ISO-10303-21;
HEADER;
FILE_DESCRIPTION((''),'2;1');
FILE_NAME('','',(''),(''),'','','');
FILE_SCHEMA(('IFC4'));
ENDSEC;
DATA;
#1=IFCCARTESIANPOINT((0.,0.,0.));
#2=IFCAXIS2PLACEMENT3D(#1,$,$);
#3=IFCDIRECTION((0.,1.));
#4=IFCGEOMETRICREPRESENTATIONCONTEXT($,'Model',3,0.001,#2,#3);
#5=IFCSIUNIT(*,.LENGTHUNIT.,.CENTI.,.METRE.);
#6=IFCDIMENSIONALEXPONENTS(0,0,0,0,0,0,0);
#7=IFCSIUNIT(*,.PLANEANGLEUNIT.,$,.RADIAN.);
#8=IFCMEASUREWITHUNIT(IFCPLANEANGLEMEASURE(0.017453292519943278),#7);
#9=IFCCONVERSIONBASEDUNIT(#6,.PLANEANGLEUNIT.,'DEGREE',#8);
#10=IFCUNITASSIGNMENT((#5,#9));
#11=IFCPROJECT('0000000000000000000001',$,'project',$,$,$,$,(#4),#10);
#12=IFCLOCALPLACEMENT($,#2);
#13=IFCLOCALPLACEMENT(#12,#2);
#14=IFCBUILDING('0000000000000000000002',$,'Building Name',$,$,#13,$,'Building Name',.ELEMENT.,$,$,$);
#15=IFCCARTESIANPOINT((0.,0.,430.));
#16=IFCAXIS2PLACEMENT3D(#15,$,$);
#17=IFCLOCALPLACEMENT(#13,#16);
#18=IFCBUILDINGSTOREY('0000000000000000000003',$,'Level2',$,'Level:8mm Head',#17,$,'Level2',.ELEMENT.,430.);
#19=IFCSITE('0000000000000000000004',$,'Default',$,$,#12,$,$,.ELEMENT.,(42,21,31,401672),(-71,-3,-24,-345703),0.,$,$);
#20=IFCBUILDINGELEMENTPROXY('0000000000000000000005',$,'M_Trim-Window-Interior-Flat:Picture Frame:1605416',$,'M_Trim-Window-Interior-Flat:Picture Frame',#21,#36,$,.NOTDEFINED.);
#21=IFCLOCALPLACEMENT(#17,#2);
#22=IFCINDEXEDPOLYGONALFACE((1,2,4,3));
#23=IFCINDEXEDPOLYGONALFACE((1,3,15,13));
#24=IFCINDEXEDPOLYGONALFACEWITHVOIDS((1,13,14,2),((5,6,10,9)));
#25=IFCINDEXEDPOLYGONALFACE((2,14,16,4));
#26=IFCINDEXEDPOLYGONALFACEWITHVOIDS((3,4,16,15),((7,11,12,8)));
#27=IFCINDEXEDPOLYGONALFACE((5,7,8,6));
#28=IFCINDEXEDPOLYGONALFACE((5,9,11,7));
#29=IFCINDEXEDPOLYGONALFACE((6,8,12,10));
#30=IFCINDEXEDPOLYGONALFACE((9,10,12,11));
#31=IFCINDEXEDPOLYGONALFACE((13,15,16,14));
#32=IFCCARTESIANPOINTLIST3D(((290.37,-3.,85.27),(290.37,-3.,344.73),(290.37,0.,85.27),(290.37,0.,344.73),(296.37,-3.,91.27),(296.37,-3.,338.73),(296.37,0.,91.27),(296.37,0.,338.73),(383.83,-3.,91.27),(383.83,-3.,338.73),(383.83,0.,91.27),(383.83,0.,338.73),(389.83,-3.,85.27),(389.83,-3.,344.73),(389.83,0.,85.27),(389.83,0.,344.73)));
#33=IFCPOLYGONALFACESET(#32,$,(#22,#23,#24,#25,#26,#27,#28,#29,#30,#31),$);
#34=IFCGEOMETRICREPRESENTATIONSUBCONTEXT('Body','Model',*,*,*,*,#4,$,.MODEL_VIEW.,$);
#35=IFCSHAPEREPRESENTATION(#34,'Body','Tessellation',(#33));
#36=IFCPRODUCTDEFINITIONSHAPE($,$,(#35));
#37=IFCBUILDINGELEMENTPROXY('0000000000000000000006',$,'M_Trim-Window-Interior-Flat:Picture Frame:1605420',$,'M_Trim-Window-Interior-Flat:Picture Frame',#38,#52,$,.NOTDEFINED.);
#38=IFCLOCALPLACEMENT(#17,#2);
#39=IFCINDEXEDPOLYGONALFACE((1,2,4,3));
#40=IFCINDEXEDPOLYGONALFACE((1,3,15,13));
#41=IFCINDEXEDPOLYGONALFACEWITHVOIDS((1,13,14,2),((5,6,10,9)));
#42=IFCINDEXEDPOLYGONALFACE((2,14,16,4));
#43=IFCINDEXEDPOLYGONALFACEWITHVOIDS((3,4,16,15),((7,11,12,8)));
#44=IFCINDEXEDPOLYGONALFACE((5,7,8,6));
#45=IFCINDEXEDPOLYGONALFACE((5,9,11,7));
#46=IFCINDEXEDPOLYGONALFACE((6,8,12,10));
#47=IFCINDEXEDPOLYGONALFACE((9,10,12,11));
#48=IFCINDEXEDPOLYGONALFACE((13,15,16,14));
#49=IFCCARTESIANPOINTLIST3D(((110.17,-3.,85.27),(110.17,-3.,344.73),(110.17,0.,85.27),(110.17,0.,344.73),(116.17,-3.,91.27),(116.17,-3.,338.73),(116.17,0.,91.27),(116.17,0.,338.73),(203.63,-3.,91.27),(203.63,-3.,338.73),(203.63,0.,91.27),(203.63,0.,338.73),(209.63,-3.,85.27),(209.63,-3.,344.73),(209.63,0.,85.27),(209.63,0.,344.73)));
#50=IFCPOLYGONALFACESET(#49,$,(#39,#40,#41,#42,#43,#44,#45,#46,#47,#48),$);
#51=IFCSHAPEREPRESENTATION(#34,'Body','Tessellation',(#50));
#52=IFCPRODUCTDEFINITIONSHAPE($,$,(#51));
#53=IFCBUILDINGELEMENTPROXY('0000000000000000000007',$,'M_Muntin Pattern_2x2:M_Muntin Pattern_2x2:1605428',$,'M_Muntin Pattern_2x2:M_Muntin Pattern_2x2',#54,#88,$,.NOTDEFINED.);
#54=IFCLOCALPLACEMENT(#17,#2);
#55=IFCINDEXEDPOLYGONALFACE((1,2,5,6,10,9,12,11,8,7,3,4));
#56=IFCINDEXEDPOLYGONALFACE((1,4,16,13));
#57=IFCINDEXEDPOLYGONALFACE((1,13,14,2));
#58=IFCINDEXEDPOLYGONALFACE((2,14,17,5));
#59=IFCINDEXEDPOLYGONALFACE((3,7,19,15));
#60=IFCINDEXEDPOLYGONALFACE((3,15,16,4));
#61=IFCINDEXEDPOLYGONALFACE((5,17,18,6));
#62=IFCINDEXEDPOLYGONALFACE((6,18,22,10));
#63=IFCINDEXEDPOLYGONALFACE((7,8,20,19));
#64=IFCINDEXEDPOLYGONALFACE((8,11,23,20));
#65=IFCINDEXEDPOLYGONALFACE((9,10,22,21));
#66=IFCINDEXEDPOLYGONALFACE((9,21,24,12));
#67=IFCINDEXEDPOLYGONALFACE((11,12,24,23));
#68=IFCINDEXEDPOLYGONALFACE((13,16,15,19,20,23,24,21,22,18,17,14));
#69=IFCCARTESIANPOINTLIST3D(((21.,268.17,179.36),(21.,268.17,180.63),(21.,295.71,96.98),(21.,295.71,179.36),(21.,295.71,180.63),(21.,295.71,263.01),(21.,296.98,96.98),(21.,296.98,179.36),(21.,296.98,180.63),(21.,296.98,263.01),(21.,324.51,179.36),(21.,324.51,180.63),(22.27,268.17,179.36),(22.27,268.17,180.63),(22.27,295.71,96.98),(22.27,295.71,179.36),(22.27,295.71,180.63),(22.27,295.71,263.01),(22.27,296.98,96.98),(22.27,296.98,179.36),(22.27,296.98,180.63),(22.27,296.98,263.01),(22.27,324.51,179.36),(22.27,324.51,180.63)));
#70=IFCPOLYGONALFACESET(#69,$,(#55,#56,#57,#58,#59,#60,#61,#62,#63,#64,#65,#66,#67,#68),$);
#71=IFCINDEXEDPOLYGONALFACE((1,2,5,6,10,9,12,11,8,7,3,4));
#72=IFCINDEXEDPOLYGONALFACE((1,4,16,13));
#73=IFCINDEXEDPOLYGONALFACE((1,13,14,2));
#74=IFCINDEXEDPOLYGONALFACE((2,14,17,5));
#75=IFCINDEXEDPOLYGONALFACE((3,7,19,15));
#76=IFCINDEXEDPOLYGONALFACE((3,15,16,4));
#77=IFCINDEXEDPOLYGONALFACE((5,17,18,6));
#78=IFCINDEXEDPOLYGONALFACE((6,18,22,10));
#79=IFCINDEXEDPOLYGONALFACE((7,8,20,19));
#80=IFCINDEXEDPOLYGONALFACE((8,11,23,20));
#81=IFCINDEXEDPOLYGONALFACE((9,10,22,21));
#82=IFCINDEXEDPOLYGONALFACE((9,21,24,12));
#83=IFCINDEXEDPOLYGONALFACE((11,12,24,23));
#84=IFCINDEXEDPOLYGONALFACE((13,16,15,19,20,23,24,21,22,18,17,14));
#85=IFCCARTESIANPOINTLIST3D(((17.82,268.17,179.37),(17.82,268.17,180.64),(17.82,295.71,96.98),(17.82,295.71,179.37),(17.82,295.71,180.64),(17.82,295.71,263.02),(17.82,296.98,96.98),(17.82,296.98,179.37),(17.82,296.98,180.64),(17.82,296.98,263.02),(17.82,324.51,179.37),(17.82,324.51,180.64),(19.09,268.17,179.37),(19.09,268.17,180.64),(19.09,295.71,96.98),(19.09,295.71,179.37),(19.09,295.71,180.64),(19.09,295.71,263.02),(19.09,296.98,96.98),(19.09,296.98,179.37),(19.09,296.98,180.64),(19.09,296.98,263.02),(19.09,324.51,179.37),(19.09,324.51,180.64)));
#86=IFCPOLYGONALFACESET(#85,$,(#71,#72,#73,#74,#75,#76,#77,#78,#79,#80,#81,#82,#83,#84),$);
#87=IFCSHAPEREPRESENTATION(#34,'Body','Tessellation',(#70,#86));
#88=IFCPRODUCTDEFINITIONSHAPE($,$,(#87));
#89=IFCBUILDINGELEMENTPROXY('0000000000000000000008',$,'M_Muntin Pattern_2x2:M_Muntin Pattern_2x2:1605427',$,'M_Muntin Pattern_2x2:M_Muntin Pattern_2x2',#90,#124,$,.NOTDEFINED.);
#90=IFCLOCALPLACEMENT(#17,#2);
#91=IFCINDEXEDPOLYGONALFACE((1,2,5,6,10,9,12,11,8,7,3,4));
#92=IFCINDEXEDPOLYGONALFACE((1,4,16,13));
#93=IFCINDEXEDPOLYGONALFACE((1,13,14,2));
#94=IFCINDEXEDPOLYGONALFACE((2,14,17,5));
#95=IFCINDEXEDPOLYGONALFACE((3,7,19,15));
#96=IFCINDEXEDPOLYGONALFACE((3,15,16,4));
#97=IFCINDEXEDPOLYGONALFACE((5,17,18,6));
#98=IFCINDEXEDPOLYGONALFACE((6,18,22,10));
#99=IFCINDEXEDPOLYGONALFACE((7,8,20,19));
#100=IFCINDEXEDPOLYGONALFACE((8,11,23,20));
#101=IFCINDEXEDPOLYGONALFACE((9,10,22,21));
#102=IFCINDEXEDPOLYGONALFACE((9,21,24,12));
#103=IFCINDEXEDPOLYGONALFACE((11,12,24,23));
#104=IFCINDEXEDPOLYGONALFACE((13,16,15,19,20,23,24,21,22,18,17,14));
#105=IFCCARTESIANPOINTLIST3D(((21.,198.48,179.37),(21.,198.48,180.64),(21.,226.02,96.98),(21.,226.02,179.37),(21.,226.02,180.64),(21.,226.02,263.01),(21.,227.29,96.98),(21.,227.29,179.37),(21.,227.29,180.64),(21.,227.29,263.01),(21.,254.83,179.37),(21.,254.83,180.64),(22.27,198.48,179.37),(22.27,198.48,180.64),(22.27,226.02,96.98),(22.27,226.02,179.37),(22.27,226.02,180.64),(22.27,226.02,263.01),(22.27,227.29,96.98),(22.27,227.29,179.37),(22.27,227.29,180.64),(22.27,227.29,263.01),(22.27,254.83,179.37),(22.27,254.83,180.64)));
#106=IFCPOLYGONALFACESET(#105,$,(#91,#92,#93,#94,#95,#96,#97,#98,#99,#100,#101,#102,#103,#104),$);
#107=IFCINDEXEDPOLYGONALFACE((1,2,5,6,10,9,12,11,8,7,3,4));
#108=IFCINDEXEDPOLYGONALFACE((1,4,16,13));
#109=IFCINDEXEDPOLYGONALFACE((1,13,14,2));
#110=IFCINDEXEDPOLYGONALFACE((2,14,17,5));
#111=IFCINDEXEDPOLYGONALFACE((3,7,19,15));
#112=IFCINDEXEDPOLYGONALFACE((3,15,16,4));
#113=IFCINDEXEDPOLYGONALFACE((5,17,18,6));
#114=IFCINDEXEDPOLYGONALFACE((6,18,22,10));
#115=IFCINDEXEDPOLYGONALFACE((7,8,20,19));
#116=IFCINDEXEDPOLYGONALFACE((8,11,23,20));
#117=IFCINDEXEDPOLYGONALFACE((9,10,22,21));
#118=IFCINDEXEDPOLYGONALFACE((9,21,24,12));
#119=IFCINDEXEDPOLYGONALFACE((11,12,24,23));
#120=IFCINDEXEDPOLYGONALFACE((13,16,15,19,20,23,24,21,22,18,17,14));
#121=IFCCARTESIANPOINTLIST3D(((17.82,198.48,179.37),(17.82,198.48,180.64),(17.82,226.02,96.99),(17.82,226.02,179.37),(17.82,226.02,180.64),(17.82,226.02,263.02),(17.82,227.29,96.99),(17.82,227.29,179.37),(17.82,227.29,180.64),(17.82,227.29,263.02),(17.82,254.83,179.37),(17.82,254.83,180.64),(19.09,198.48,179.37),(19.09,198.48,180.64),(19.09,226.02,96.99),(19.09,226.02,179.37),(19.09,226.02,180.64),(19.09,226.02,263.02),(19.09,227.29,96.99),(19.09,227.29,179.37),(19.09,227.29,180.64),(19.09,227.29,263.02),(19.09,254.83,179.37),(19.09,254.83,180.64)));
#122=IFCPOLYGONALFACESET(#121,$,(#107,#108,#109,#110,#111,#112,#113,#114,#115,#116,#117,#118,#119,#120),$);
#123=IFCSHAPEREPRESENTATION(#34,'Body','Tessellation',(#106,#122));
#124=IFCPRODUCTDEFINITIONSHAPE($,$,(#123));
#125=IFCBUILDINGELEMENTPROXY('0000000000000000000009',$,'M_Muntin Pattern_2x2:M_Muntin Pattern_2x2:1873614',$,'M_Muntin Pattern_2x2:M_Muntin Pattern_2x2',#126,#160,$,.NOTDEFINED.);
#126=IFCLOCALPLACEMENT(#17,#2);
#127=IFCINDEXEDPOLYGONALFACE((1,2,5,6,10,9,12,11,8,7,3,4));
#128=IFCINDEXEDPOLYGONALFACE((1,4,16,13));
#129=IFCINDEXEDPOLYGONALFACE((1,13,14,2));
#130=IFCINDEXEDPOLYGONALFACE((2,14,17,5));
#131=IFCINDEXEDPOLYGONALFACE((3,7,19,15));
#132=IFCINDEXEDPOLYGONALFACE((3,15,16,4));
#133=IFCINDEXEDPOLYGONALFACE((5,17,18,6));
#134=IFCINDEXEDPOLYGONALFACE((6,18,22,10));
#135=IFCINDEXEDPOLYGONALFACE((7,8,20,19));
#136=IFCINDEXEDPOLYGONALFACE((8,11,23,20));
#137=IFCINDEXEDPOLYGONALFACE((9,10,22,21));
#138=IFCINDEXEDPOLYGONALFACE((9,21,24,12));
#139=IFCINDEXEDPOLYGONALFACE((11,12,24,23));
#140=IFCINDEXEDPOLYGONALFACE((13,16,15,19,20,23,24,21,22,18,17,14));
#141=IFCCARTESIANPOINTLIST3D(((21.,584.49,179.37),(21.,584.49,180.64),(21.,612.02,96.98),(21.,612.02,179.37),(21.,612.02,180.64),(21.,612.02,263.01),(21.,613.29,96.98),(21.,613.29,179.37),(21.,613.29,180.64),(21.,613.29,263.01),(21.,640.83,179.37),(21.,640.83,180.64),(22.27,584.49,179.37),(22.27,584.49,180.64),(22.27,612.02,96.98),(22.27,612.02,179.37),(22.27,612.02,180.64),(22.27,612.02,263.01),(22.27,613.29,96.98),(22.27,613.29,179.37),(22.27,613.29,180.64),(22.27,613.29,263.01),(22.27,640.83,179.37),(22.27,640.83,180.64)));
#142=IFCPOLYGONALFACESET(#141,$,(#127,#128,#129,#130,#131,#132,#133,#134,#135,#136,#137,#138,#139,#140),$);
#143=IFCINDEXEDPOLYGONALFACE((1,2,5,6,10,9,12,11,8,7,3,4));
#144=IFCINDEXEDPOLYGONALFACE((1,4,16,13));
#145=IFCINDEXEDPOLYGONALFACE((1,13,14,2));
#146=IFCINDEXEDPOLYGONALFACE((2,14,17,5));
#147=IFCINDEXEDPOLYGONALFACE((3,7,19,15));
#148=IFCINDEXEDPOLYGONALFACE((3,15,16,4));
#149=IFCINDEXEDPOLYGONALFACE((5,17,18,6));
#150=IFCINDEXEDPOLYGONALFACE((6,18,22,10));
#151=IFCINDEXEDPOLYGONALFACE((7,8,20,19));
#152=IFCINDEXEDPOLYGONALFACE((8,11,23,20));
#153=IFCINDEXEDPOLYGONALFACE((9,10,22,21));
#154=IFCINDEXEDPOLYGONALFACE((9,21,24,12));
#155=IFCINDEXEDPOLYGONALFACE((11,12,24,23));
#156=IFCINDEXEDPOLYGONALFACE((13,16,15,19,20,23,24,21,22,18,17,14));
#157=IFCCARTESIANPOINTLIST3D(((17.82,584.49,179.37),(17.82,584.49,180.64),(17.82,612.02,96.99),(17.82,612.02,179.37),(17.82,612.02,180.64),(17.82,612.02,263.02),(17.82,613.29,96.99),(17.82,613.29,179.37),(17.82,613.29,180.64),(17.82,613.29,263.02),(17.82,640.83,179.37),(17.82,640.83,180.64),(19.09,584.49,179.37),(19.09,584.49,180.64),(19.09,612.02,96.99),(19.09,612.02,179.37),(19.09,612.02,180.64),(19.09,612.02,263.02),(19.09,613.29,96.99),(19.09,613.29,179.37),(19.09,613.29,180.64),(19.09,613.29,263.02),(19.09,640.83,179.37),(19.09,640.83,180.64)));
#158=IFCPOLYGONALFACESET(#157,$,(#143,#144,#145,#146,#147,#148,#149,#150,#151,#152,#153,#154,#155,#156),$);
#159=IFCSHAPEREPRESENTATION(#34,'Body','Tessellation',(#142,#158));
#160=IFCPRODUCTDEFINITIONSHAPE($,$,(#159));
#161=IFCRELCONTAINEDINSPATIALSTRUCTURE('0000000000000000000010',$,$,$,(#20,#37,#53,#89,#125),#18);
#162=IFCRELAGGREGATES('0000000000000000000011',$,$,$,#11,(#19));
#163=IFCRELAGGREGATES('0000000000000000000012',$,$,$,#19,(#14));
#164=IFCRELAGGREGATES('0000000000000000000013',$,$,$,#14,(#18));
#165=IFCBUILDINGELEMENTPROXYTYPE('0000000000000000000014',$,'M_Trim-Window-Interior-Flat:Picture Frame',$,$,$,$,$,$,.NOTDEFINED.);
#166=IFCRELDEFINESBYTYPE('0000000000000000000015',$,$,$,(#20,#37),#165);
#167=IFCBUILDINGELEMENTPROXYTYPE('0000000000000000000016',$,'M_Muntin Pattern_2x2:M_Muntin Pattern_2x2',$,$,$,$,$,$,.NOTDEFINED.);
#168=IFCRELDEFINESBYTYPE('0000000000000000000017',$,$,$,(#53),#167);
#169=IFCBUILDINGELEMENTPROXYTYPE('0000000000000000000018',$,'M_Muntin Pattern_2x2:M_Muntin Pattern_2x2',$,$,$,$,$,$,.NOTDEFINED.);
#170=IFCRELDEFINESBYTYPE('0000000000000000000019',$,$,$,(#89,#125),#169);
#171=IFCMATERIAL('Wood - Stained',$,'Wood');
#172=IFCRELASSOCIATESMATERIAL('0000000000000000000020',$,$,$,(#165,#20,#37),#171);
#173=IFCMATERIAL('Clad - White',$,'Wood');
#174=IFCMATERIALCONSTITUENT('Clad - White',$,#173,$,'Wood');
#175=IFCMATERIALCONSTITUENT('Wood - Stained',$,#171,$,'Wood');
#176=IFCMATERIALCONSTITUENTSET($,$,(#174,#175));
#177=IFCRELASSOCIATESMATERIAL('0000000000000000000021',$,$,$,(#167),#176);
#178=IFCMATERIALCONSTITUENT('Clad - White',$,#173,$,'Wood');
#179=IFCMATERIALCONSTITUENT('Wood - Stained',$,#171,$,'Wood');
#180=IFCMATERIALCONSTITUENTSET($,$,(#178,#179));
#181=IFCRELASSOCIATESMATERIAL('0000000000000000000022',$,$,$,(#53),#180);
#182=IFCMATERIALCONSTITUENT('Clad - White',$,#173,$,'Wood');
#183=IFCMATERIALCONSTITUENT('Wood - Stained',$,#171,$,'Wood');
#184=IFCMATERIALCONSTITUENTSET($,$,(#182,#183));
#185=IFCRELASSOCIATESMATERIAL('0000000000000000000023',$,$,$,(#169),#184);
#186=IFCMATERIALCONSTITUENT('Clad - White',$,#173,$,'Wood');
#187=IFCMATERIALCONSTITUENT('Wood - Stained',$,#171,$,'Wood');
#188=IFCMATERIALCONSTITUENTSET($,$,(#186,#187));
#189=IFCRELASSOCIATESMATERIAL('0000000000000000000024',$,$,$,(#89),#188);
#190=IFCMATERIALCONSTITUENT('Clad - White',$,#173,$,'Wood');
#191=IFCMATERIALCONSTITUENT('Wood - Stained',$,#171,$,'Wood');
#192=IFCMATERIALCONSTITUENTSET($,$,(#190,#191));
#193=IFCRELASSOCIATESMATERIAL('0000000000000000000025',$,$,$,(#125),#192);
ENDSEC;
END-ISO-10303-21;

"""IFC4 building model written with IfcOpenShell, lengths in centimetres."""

from ifc_helpers import new_model, entity, si_unit, converted_unit, direction, frame, origin, place, context, subcontext, project, spatial, indexed_curve, outline, extrude, source, transform, mapped, material, constituent, constituent_set, type_object, type_shapes, element, save


model = new_model("IFC4")

# Units and contexts
model_context = context("Model", 3, precision=0.001, world=origin(), true_north=direction((0.0, 1.0)))
body_context = subcontext(model_context, "Body", "Model", "MODEL_VIEW")
ifc_project = project(units=[si_unit("LENGTHUNIT", "METRE", prefix="CENTI"), converted_unit("PLANEANGLEUNIT", "DEGREE", entity("IfcPlaneAngleMeasure", 0.017453292519943278), si_unit("PLANEANGLEUNIT", "RADIAN"), dimensions=[0, 0, 0, 0, 0, 0, 0])], contexts=[model_context])

# Site, building, storey
site_placement = place(None, origin())
site = spatial("IfcSite", under=ifc_project, at=site_placement, Name="Default", CompositionType="ELEMENT", RefLatitude=(42, 21, 31, 401672), RefLongitude=(-71, -3, -24, -345703), RefElevation=0.0)
building_placement = place(site_placement, origin())
building = spatial("IfcBuilding", under=site, at=building_placement, Name="Building Name", LongName="Building Name", CompositionType="ELEMENT")
storey_placement = place(building_placement, frame((0.0, 0.0, 430.0)))
storey = spatial("IfcBuildingStorey", under=building, at=storey_placement, Name="Level2", ObjectType="Level:8mm Head", LongName="Level2", CompositionType="ELEMENT", Elevation=430.0)

# Building element proxies
ifc_material_1 = material(Name="Clad - White", Category="Wood")
ifc_material_2 = material(Name="Wood - Stained", Category="Wood")
building_element_proxy_type_1 = type_object("IfcBuildingElementProxyType", Name="M_Trim-Window-Interior-Flat:Picture Frame", PredefinedType="NOTDEFINED", material=ifc_material_2)
shared_shape_1 = source(origin(), body_context, "Body", "SweptSolid", [
    extrude(outline(indexed_curve([(-129.73, -49.73), (129.73, -49.73), (129.73, 49.73), (-129.73, 49.73), (-129.73, -49.73)], self_intersect=False), holes=[indexed_curve([(-123.73, -43.73), (-123.73, 43.73), (123.73, 43.73), (123.73, -43.73), (-123.73, -43.73)], self_intersect=False)]), frame((0.0, 125.0, 0.0), z_axis=(0.0, 0.0, 1.0), x_axis=(0.0, 1.0, 0.0)), (0.0, 0.0, 1.0), 3.0),
])
type_shapes(building_element_proxy_type_1, [shared_shape_1])
for number, where, z_axis, x_axis, name in (
    (1, (340.1, 0.0, 340.0), (0.0, -1.0, 0.0), (-1.0, 0.0, 0.0), "M_Trim-Window-Interior-Flat:Picture Frame:1605416"),
    (2, (159.9, 0.0, 340.0), (0.0, -1.0, 0.0), (-1.0, 0.0, 0.0), "M_Trim-Window-Interior-Flat:Picture Frame:1605420"),
):
    element("IfcBuildingElementProxy", number, at=place(storey_placement, frame(where, z_axis=z_axis, x_axis=x_axis)), inside=storey, type_object=building_element_proxy_type_1, material=ifc_material_2, Name=name, ObjectType="M_Trim-Window-Interior-Flat:Picture Frame", PredefinedType="NOTDEFINED", context=body_context, shape_type="MappedRepresentation", body=[
        mapped(shared_shape_1, transform((0.0, 0.0, 0.0), scale=1.0)),
    ])
ifc_constituent_1 = constituent(ifc_material_1, Name="Clad - White", Category="Wood")
ifc_constituent_2 = constituent(ifc_material_2, Name="Wood - Stained", Category="Wood")
ifc_constituent_set_1 = constituent_set(constituents=[ifc_constituent_1, ifc_constituent_2])
ifc_constituent_3 = constituent(ifc_material_1, Name="Clad - White", Category="Wood")
ifc_constituent_4 = constituent(ifc_material_2, Name="Wood - Stained", Category="Wood")
ifc_constituent_set_2 = constituent_set(constituents=[ifc_constituent_3, ifc_constituent_4])
building_element_proxy_type_2 = type_object("IfcBuildingElementProxyType", Name="M_Muntin Pattern_2x2:M_Muntin Pattern_2x2", PredefinedType="NOTDEFINED", material=ifc_constituent_set_2)
shared_shape_2 = source(origin(), body_context, "Body", "SweptSolid", [
    extrude(outline(indexed_curve([(0.64, -0.64), (83.01, -0.64), (83.01, 0.63), (0.64, 0.63), (0.64, 28.17), (-0.63, 28.17), (-0.63, 0.63), (-83.02, 0.63), (-83.02, -0.64), (-0.63, -0.64), (-0.63, -28.17), (0.64, -28.17), (0.64, -0.64)], self_intersect=False)), frame((0.0, 0.95, 83.01), z_axis=(0.0, 1.0, 0.0), x_axis=(0.0, 0.0, 1.0)), (0.0, 0.0, 1.0), 1.27),
    extrude(outline(indexed_curve([(0.64, -0.64), (83.02, -0.64), (83.02, 0.63), (0.64, 0.63), (0.64, 28.17), (-0.63, 28.17), (-0.63, 0.63), (-83.02, 0.63), (-83.02, -0.64), (-0.63, -0.64), (-0.63, -28.17), (0.64, -28.17), (0.64, -0.64)], self_intersect=False)), frame((0.0, -2.22, 83.02), z_axis=(0.0, 1.0, 0.0), x_axis=(0.0, 0.0, 1.0)), (0.0, 0.0, 1.0), 1.27),
])
type_shapes(building_element_proxy_type_2, [shared_shape_2])
proxy_1_placement = place(storey_placement, frame((20.05, 296.34, 96.98), z_axis=(0.0, 0.0, 1.0), x_axis=(0.0, -1.0, 0.0)))
element("IfcBuildingElementProxy", 3, at=proxy_1_placement, inside=storey, type_object=building_element_proxy_type_2, material=ifc_constituent_set_1, Name="M_Muntin Pattern_2x2:M_Muntin Pattern_2x2:1605428", ObjectType="M_Muntin Pattern_2x2:M_Muntin Pattern_2x2", PredefinedType="NOTDEFINED", context=body_context, shape_type="MappedRepresentation", body=[
    mapped(shared_shape_2, transform((0.0, 0.0, 0.0), scale=1.0)),
])
ifc_constituent_5 = constituent(ifc_material_1, Name="Clad - White", Category="Wood")
ifc_constituent_6 = constituent(ifc_material_2, Name="Wood - Stained", Category="Wood")
ifc_constituent_set_3 = constituent_set(constituents=[ifc_constituent_5, ifc_constituent_6])
ifc_constituent_7 = constituent(ifc_material_1, Name="Clad - White", Category="Wood")
ifc_constituent_8 = constituent(ifc_material_2, Name="Wood - Stained", Category="Wood")
ifc_constituent_set_4 = constituent_set(constituents=[ifc_constituent_7, ifc_constituent_8])
building_element_proxy_type_3 = type_object("IfcBuildingElementProxyType", Name="M_Muntin Pattern_2x2:M_Muntin Pattern_2x2", PredefinedType="NOTDEFINED", material=ifc_constituent_set_4)
shared_shape_3 = source(origin(), body_context, "Body", "SweptSolid", [
    extrude(outline(indexed_curve([(0.64, -0.64), (83.01, -0.64), (83.01, 0.63), (0.64, 0.63), (0.64, 28.17), (-0.63, 28.17), (-0.63, 0.63), (-83.02, 0.63), (-83.02, -0.64), (-0.63, -0.64), (-0.63, -28.17), (0.64, -28.17), (0.64, -0.64)], self_intersect=False)), frame((0.0, -2.22, 83.01), z_axis=(0.0, 1.0, 0.0), x_axis=(0.0, 0.0, 1.0)), (0.0, 0.0, 1.0), 1.27),
    extrude(outline(indexed_curve([(0.64, -0.64), (83.02, -0.64), (83.02, 0.63), (0.64, 0.63), (0.64, 28.17), (-0.63, 28.17), (-0.63, 0.63), (-83.02, 0.63), (-83.02, -0.64), (-0.63, -0.64), (-0.63, -28.17), (0.64, -28.17), (0.64, -0.64)], self_intersect=False)), frame((0.0, 0.95, 83.02), z_axis=(0.0, 1.0, 0.0), x_axis=(0.0, 0.0, 1.0)), (0.0, 0.0, 1.0), 1.27),
])
type_shapes(building_element_proxy_type_3, [shared_shape_3])
proxy_2_placement = place(storey_placement, frame((20.05, 226.66, 96.99), z_axis=(0.0, 0.0, 1.0), x_axis=(0.0, 1.0, 0.0)))
element("IfcBuildingElementProxy", 4, at=proxy_2_placement, inside=storey, type_object=building_element_proxy_type_3, material=ifc_constituent_set_3, Name="M_Muntin Pattern_2x2:M_Muntin Pattern_2x2:1605427", ObjectType="M_Muntin Pattern_2x2:M_Muntin Pattern_2x2", PredefinedType="NOTDEFINED", context=body_context, shape_type="MappedRepresentation", body=[
    mapped(shared_shape_3, transform((0.0, 0.0, 0.0), scale=1.0)),
])
ifc_constituent_9 = constituent(ifc_material_1, Name="Clad - White", Category="Wood")
ifc_constituent_10 = constituent(ifc_material_2, Name="Wood - Stained", Category="Wood")
ifc_constituent_set_5 = constituent_set(constituents=[ifc_constituent_9, ifc_constituent_10])
proxy_3_placement = place(storey_placement, frame((20.05, 612.66, 96.99), z_axis=(0.0, 0.0, 1.0), x_axis=(0.0, 1.0, 0.0)))
element("IfcBuildingElementProxy", 5, at=proxy_3_placement, inside=storey, type_object=building_element_proxy_type_3, material=ifc_constituent_set_5, Name="M_Muntin Pattern_2x2:M_Muntin Pattern_2x2:1873614", ObjectType="M_Muntin Pattern_2x2:M_Muntin Pattern_2x2", PredefinedType="NOTDEFINED", context=body_context, shape_type="MappedRepresentation", body=[
    mapped(shared_shape_3, transform((0.0, 0.0, 0.0), scale=1.0)),
])

save(model, "model.ifc")
